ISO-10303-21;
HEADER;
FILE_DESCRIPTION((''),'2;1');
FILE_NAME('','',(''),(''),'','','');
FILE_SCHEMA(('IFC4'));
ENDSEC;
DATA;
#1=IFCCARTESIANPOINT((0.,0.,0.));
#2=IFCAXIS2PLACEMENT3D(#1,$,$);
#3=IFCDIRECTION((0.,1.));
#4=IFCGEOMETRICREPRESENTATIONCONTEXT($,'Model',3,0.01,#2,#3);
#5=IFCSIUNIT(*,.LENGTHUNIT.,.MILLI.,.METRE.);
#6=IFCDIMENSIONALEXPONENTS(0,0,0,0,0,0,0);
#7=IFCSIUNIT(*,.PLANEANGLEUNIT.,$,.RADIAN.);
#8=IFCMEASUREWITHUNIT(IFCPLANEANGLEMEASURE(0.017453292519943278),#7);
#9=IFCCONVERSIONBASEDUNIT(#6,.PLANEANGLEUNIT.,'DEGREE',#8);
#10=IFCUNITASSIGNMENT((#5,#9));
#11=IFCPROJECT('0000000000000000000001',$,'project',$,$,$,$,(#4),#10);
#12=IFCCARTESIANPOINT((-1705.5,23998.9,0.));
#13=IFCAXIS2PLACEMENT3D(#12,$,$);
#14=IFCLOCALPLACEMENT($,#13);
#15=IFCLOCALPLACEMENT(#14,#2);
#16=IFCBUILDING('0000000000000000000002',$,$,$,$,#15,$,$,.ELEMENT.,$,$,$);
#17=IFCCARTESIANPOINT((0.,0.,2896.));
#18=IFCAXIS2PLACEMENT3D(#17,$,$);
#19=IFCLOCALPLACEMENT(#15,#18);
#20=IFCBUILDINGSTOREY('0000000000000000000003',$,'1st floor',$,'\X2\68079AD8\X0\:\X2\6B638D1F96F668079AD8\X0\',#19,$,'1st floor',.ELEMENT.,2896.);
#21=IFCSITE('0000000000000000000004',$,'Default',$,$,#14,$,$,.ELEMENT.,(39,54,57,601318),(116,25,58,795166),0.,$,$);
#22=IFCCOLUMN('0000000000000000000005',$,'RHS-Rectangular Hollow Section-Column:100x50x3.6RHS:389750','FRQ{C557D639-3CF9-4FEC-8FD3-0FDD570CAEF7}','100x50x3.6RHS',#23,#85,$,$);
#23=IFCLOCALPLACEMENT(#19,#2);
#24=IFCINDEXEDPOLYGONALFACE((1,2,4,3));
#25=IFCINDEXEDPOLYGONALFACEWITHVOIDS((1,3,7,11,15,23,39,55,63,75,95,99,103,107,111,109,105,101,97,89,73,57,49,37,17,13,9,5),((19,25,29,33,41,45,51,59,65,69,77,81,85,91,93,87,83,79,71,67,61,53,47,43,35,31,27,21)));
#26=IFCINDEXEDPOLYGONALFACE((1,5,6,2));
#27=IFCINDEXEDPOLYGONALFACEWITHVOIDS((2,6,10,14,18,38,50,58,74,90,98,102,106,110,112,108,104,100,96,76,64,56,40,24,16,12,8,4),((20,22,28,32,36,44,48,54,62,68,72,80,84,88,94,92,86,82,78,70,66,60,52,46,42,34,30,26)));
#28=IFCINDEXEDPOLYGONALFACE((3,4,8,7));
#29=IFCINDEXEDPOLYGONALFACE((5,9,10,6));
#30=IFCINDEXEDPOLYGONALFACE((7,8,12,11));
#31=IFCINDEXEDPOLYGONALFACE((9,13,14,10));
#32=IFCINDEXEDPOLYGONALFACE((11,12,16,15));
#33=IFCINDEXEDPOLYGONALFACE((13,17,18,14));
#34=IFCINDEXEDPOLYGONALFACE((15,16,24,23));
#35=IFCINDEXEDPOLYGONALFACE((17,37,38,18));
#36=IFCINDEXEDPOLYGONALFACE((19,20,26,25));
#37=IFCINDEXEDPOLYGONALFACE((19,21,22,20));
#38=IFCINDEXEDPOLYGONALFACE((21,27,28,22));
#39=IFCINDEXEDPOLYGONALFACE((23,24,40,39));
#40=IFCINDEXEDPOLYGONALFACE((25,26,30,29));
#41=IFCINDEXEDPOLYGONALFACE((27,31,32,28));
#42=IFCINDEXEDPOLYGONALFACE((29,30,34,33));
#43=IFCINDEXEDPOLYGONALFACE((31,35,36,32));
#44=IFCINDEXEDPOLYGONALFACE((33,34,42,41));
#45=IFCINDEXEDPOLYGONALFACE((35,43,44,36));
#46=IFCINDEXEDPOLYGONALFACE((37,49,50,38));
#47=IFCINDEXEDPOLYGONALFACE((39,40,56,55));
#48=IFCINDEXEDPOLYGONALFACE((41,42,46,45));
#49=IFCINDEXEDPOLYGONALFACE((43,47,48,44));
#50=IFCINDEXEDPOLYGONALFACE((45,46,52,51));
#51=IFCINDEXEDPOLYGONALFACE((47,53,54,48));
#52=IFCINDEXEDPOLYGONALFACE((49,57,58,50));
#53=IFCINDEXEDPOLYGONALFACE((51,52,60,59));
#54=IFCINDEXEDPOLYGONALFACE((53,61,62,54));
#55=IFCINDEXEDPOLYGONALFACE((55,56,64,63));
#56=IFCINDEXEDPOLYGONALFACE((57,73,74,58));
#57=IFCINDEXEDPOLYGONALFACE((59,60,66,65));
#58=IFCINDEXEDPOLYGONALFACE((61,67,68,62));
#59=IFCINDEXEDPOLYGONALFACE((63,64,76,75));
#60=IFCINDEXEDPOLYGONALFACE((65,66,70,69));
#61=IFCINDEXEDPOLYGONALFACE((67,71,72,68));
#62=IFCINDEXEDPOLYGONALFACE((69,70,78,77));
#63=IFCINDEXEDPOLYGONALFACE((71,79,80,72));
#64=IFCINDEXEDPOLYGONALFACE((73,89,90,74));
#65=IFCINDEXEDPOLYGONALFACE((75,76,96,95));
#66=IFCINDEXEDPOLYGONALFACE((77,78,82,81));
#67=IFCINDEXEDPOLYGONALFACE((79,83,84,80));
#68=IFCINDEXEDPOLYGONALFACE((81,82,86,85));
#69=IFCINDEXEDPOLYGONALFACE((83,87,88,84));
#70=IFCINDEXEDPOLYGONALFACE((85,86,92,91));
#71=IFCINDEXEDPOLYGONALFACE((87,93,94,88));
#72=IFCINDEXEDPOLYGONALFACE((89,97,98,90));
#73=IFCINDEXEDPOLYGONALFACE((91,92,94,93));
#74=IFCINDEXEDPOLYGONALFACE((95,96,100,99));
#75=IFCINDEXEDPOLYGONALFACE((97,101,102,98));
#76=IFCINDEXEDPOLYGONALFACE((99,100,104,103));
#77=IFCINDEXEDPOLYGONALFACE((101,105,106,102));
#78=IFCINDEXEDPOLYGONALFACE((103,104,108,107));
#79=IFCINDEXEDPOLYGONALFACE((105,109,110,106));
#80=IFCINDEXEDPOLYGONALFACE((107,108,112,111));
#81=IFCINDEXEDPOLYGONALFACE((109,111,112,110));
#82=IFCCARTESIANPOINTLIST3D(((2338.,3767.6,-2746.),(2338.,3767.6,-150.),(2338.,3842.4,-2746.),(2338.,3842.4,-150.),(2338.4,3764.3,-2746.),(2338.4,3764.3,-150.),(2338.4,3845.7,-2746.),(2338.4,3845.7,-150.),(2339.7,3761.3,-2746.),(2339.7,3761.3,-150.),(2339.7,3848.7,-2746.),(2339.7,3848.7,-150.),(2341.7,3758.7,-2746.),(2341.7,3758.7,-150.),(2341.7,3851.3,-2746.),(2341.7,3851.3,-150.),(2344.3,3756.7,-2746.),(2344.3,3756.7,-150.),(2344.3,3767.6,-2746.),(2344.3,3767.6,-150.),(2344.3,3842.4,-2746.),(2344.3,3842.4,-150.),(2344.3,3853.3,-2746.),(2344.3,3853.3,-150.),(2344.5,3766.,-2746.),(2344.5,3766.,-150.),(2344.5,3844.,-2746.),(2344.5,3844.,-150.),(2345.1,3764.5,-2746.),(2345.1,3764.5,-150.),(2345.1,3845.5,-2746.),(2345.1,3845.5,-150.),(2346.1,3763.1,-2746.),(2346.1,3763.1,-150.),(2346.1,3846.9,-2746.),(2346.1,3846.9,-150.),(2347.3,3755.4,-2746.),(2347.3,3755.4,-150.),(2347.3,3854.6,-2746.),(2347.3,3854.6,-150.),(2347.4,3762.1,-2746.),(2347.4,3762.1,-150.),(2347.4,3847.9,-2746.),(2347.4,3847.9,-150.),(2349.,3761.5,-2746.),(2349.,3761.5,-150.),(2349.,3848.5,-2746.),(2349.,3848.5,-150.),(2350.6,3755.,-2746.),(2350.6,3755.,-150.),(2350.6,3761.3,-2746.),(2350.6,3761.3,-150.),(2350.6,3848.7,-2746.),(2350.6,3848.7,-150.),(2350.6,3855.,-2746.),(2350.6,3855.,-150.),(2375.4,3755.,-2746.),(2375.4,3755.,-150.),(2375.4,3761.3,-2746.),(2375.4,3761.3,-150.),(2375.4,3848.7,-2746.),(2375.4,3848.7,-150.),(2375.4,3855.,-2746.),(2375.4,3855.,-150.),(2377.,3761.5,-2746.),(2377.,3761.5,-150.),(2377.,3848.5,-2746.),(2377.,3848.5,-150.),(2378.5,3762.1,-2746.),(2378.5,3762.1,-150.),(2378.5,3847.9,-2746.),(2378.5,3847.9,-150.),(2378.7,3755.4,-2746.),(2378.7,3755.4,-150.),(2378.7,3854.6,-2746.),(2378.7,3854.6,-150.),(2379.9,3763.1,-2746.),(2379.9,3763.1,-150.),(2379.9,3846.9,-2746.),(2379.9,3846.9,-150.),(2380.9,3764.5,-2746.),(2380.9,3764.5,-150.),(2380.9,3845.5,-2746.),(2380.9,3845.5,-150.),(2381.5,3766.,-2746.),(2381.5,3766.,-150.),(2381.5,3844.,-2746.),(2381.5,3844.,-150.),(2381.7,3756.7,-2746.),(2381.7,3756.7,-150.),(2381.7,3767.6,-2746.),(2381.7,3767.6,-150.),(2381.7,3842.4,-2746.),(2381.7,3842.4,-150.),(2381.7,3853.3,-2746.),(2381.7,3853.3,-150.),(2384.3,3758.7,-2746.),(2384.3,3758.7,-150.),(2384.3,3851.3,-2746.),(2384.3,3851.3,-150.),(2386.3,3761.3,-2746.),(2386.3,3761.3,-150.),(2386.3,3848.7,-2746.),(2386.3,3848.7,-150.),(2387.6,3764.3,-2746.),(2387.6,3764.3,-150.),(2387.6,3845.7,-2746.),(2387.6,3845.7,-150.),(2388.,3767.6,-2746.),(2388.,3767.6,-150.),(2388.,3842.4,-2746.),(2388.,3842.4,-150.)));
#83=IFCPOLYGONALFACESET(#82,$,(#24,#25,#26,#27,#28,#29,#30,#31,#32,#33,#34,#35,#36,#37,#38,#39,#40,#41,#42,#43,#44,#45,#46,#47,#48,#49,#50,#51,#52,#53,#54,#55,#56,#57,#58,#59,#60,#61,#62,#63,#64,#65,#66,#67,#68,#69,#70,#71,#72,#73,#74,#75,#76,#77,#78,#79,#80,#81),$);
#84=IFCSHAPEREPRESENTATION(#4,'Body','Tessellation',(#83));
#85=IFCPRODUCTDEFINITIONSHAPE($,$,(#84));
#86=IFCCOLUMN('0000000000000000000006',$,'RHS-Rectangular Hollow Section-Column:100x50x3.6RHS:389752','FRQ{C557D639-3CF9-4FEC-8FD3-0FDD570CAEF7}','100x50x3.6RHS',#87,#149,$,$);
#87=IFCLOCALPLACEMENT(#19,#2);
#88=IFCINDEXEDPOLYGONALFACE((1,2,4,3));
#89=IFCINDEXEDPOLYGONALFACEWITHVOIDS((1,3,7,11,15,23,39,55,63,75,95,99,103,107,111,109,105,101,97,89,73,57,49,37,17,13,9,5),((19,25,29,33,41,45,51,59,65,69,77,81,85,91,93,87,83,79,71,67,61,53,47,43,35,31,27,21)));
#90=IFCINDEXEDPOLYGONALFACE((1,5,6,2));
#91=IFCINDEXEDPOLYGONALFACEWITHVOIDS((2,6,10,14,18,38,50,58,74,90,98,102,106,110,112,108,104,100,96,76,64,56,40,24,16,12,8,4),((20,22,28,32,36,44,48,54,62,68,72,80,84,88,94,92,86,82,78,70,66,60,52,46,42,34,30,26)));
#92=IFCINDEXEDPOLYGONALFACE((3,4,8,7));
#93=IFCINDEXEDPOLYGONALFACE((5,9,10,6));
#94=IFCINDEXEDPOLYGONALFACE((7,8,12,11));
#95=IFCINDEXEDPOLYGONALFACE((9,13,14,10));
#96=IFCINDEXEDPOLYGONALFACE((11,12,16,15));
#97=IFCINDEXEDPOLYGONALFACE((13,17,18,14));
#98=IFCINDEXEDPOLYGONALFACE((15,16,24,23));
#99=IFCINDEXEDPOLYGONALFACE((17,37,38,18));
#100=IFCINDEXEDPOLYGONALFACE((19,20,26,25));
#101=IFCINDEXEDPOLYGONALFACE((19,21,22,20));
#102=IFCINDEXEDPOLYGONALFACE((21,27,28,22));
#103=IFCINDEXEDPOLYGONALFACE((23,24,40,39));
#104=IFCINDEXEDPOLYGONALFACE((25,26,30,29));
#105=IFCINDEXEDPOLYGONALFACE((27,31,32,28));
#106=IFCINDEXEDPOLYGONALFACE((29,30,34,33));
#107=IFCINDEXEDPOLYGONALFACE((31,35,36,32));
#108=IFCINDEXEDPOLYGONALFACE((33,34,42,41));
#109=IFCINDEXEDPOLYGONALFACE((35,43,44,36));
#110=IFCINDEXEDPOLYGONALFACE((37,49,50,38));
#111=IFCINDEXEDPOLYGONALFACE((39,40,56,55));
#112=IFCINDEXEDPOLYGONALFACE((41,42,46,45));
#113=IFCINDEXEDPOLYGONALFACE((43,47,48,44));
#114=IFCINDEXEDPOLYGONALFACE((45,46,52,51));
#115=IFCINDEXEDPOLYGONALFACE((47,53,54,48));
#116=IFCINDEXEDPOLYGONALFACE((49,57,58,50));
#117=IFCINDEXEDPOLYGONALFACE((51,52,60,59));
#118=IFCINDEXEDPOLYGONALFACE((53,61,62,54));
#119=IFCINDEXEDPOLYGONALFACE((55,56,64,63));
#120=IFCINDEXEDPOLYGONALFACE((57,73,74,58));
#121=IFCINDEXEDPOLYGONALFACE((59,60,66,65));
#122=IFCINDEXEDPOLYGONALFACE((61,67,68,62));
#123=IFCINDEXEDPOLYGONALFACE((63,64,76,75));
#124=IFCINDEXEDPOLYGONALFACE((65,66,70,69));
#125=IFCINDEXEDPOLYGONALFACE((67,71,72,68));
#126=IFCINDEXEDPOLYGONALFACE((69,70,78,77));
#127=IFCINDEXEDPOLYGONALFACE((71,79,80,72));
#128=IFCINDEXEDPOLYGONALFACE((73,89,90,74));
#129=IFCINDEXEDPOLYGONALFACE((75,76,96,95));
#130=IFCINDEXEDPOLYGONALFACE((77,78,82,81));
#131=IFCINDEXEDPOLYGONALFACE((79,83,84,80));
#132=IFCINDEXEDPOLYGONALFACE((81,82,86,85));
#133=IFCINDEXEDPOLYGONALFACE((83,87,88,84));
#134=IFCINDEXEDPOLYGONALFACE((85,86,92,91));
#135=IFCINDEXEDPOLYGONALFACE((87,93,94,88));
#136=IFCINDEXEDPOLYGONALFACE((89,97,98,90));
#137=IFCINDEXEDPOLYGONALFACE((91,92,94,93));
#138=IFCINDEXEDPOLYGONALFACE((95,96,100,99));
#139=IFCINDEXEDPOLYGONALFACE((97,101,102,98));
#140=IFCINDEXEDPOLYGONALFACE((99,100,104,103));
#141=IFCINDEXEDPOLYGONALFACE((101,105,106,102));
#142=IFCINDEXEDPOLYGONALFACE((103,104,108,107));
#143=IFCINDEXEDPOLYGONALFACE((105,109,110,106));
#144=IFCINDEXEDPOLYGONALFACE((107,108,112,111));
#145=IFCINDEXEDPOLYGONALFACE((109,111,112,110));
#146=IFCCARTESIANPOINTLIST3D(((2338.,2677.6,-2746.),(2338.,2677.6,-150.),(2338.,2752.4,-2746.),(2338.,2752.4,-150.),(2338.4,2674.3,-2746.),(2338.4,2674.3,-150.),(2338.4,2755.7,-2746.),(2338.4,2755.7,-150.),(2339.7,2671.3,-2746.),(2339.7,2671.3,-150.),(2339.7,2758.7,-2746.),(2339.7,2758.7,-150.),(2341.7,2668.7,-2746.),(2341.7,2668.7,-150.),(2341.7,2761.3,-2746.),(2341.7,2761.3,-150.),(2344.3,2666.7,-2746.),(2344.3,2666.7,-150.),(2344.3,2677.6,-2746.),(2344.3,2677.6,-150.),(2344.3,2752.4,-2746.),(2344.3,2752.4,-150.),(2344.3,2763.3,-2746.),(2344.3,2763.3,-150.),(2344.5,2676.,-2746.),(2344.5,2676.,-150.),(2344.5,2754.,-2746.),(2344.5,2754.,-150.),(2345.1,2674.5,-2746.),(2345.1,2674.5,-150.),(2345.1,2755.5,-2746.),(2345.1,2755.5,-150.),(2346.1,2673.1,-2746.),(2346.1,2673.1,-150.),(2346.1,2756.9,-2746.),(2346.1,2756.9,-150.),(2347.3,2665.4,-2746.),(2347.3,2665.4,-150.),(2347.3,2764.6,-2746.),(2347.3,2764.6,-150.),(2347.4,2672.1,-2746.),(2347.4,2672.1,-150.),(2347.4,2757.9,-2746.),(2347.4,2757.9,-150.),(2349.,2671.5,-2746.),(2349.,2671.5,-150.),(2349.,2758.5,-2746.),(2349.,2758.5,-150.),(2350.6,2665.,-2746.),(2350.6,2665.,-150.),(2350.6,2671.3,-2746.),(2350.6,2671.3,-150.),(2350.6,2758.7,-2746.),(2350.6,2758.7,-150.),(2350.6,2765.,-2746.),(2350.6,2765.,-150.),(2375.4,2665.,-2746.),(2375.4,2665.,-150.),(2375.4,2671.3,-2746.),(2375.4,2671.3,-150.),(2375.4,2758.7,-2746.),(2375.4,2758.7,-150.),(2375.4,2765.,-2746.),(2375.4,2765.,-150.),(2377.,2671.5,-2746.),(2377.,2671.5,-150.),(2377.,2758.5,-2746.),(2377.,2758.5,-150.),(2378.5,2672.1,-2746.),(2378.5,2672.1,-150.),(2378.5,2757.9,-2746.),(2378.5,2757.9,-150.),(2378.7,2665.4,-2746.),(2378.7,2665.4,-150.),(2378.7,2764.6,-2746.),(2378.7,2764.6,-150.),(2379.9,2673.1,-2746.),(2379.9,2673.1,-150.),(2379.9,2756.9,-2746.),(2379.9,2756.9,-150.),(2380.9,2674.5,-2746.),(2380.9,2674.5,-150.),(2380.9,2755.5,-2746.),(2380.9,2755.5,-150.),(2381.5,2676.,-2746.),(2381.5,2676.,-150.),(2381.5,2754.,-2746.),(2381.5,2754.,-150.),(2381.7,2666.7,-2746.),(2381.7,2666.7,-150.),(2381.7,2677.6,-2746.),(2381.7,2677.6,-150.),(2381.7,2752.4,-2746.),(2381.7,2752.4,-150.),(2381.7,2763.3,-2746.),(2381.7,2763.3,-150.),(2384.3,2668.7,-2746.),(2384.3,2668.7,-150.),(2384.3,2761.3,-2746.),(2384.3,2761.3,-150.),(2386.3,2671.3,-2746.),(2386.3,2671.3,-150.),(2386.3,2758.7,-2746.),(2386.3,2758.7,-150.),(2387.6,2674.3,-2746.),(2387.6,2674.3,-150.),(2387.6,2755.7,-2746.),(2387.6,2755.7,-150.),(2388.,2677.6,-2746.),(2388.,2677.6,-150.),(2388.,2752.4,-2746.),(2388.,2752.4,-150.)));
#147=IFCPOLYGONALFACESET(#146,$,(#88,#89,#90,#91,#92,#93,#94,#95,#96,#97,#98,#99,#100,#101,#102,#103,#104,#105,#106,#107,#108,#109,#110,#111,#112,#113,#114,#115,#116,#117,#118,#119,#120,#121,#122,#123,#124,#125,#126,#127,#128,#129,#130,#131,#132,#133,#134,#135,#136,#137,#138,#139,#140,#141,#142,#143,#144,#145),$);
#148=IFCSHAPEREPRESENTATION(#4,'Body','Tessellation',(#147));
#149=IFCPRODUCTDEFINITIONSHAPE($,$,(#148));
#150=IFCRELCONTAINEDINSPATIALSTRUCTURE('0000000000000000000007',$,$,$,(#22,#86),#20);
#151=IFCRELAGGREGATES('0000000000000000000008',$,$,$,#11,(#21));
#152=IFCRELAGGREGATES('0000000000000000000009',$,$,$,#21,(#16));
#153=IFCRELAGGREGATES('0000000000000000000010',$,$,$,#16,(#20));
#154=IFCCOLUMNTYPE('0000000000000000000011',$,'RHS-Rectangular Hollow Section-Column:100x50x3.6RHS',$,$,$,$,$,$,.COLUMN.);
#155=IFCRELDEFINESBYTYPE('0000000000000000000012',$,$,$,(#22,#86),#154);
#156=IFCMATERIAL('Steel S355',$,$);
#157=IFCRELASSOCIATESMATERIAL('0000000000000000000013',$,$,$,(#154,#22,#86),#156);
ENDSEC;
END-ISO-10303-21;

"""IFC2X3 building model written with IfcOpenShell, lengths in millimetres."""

from ifc_helpers import new_model, entity, si_unit, converted_unit, direction, frame, origin, origin_2d, place, context, project, spatial, hollow_rectangle, extrude, clip, halfspace, material, type_object, element, save


model = new_model("IFC2X3")

# Units and contexts
model_context = context("Model", 3, precision=0.01, world=origin(), true_north=direction((0.0, 1.0)))
ifc_project = project(units=[si_unit("LENGTHUNIT", "METRE", prefix="MILLI"), converted_unit("PLANEANGLEUNIT", "DEGREE", entity("IfcPlaneAngleMeasure", 0.017453292519943278), si_unit("PLANEANGLEUNIT", "RADIAN"), dimensions=[0, 0, 0, 0, 0, 0, 0])], contexts=[model_context])

# Site, building, storey
site_placement = place(None, frame((-1705.5, 23998.9, 0.0)))
site = spatial("IfcSite", under=ifc_project, at=site_placement, Name="Default", CompositionType="ELEMENT", RefLatitude=(39, 54, 57, 601318), RefLongitude=(116, 25, 58, 795166), RefElevation=0.0)
building_placement = place(site_placement, origin())
building = spatial("IfcBuilding", under=site, at=building_placement, CompositionType="ELEMENT")
storey_placement = place(building_placement, frame((0.0, 0.0, 2896.0)))
storey = spatial("IfcBuildingStorey", under=building, at=storey_placement, Name="1st floor", ObjectType="标高:正负零标高", LongName="1st floor", CompositionType="ELEMENT", Elevation=2896.0)

# Columns
ifc_material_1 = material(Name="Steel S355")
column_type_1 = type_object("IfcColumnType", Name="RHS-Rectangular Hollow Section-Column:100x50x3.6RHS", PredefinedType="COLUMN", material=ifc_material_1)
column_1_placement = place(storey_placement, frame((2363.0, 3805.0, -150.0), z_axis=(0.0, 0.0, 1.0), x_axis=(-1.0, 0.0, 0.0)))
element("IfcColumn", 1, at=column_1_placement, inside=storey, type_object=column_type_1, material=ifc_material_1, Name="RHS-Rectangular Hollow Section-Column:100x50x3.6RHS:389750", Description="FRQ{C557D639-3CF9-4FEC-8FD3-0FDD570CAEF7}", ObjectType="100x50x3.6RHS", context=model_context, shape_type="Clipping", body=[
    clip(extrude(hollow_rectangle(XDim=50.0, YDim=100.0, WallThickness=6.3, InnerFilletRadius=6.3, OuterFilletRadius=12.6, at=origin_2d()), origin(), (0.0, 0.0, -1.0), 2651.9), halfspace(frame((2363.0, 3805.0, -2596.0), z_axis=(0.0, 0.0, 1.0), x_axis=(-1.0, 0.0, 0.0)), True)),
])
column_2_placement = place(storey_placement, frame((2363.0, 2715.0, -150.0), z_axis=(0.0, 0.0, 1.0), x_axis=(-1.0, 0.0, 0.0)))
element("IfcColumn", 2, at=column_2_placement, inside=storey, type_object=column_type_1, material=ifc_material_1, Name="RHS-Rectangular Hollow Section-Column:100x50x3.6RHS:389752", Description="FRQ{C557D639-3CF9-4FEC-8FD3-0FDD570CAEF7}", ObjectType="100x50x3.6RHS", context=model_context, shape_type="Clipping", body=[
    clip(extrude(hollow_rectangle(XDim=50.0, YDim=100.0, WallThickness=6.3, InnerFilletRadius=6.3, OuterFilletRadius=12.6, at=origin_2d()), origin(), (0.0, 0.0, -1.0), 2651.9), halfspace(frame((2363.0, 2715.0, -2596.0), z_axis=(0.0, 0.0, 1.0), x_axis=(-1.0, 0.0, 0.0)), True)),
])

save(model, "model.ifc")
